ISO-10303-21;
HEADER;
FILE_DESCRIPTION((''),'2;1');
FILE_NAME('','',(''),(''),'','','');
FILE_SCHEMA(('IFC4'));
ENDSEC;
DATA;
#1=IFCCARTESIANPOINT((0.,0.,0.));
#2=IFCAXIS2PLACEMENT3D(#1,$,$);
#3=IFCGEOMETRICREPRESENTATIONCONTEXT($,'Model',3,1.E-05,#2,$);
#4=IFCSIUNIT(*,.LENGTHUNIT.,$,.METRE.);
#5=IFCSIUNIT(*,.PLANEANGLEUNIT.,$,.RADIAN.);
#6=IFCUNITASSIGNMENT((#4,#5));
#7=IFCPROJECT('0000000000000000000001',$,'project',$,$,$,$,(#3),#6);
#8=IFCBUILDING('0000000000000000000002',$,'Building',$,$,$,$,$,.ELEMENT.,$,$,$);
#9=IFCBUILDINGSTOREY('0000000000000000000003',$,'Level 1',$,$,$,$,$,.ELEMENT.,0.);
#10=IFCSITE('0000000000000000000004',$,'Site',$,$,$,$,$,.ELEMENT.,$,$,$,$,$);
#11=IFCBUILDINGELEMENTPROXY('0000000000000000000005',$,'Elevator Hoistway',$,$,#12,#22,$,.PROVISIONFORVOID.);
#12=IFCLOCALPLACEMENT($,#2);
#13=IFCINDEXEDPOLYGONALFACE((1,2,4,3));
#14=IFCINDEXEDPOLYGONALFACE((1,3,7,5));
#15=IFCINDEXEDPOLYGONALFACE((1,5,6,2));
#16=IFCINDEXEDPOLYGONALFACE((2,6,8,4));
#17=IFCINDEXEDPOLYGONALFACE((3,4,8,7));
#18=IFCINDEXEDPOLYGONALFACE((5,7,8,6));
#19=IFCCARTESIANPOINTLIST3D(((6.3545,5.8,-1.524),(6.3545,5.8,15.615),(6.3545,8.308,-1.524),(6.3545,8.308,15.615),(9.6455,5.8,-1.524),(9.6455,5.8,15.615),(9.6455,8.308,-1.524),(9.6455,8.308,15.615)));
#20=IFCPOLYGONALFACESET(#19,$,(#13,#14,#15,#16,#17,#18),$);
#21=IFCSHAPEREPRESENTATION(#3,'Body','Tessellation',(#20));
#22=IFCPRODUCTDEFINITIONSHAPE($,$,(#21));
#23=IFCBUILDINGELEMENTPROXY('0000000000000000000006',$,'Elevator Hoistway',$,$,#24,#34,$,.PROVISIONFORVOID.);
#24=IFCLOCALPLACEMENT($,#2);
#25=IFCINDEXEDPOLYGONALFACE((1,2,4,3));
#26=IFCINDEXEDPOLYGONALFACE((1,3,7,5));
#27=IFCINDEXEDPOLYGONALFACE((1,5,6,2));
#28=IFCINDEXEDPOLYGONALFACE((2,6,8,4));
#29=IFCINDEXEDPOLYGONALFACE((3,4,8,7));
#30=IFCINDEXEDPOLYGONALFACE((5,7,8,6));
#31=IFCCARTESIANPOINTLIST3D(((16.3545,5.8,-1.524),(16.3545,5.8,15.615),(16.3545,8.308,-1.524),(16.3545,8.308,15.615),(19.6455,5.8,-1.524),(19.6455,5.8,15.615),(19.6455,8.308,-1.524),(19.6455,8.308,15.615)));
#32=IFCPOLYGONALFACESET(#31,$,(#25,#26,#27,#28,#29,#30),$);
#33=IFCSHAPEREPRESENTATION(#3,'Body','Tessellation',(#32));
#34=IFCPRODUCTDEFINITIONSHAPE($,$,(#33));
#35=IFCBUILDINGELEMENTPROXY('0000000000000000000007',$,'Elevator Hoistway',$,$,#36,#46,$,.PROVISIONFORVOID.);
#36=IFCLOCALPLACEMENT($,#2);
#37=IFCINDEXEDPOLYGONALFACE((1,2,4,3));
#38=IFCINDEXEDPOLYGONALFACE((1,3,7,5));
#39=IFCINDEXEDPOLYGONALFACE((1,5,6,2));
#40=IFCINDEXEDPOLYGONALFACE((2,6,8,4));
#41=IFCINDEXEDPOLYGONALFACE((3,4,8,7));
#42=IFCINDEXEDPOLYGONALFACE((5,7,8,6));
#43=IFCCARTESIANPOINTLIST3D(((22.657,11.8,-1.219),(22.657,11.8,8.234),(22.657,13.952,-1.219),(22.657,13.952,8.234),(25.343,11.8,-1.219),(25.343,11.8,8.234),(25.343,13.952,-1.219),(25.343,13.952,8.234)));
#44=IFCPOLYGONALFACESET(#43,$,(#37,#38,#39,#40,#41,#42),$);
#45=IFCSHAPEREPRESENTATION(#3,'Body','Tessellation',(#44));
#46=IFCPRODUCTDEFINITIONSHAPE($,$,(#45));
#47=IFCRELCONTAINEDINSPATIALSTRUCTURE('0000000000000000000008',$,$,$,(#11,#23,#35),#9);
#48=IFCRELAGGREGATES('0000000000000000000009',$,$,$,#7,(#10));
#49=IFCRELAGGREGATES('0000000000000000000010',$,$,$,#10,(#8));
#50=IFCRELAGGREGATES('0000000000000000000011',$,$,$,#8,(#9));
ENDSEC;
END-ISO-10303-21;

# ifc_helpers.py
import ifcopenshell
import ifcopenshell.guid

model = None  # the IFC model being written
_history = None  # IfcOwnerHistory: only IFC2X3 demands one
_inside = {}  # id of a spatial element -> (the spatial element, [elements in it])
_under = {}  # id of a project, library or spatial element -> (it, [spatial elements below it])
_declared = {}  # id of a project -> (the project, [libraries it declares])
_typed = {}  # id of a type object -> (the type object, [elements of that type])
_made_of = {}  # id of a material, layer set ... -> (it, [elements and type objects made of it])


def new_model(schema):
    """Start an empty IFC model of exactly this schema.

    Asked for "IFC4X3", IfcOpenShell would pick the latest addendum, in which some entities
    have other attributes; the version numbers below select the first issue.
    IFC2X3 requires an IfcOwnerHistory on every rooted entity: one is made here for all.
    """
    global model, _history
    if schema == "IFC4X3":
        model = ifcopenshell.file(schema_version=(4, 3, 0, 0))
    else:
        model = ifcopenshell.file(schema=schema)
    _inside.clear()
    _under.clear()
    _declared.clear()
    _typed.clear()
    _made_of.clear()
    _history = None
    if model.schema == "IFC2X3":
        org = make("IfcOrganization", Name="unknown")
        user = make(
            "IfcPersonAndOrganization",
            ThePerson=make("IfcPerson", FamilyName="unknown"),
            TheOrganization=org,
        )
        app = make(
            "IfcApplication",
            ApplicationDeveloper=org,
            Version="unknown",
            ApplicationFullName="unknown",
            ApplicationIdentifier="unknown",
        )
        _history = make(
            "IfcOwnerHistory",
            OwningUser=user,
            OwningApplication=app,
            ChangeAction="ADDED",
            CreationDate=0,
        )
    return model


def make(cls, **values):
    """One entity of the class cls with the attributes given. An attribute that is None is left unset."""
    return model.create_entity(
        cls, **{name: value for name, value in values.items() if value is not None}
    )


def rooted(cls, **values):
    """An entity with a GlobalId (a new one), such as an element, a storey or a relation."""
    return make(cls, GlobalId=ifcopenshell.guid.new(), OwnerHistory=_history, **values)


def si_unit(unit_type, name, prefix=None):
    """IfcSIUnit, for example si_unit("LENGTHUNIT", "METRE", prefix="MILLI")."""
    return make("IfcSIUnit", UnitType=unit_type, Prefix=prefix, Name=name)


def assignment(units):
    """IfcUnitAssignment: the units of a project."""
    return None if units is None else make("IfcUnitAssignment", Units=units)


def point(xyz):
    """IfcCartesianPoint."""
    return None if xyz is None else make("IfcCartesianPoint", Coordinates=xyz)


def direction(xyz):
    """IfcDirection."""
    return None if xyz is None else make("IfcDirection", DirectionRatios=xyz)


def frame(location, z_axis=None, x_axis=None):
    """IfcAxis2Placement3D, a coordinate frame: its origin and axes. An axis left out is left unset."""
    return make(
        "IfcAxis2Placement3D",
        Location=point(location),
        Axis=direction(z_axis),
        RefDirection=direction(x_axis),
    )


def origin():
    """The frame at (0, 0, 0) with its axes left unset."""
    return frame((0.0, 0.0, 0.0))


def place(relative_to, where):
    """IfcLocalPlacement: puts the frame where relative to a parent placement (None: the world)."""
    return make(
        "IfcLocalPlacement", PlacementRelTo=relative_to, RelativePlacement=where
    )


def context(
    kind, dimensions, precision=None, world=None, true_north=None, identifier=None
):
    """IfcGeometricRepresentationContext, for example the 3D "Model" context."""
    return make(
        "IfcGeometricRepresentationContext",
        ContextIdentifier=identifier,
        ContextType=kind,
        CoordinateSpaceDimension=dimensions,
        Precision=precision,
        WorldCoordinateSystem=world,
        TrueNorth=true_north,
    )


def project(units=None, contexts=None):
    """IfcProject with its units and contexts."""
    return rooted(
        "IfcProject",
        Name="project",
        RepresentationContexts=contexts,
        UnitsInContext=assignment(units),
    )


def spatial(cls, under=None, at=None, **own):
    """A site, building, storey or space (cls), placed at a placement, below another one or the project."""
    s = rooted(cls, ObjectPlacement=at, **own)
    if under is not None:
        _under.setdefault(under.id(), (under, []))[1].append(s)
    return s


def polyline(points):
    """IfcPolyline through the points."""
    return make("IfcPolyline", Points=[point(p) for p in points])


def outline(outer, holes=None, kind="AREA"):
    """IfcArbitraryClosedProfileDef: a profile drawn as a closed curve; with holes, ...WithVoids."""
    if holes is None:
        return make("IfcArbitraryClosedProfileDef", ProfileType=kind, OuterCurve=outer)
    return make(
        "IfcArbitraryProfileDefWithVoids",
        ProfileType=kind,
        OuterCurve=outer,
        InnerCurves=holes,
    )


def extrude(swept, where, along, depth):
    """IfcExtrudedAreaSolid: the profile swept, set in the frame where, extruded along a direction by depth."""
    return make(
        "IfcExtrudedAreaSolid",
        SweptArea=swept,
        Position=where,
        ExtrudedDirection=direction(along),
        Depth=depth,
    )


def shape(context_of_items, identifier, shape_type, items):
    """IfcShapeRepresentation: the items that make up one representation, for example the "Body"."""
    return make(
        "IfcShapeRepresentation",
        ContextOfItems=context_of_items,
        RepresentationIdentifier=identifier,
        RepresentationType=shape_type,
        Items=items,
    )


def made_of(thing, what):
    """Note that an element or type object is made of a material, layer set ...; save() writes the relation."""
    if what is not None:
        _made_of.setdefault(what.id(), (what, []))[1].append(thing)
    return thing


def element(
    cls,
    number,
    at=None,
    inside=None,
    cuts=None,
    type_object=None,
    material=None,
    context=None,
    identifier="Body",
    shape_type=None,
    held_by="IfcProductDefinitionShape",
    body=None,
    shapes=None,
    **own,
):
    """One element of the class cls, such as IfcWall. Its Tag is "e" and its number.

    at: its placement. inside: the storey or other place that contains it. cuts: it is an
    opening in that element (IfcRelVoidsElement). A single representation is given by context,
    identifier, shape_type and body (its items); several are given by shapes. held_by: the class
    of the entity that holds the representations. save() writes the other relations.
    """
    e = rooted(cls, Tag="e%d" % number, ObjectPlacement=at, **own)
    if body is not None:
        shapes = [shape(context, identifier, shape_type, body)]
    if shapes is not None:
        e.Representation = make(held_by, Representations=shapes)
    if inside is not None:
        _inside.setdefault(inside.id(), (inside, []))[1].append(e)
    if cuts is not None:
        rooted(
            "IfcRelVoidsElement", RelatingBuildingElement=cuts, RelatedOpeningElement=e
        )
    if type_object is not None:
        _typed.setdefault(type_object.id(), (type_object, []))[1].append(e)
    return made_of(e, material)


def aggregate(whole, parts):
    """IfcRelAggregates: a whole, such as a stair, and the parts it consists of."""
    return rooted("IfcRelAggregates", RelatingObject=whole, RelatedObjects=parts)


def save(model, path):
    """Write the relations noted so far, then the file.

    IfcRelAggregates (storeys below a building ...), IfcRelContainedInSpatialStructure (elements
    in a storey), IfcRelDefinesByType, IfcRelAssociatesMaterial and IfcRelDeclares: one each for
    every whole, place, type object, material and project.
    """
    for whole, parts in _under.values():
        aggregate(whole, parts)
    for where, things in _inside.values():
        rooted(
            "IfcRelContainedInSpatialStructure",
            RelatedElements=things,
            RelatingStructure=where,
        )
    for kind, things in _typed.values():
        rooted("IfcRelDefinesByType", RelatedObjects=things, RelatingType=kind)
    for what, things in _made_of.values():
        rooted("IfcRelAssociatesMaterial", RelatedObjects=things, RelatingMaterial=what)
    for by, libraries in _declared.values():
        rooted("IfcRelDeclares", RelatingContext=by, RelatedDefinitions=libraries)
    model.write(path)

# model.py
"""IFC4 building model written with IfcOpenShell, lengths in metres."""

from ifc_helpers import new_model, si_unit, frame, origin, place, context, project, spatial, polyline, outline, extrude, element, save


model = new_model("IFC4")

# Units and contexts
model_context = context("Model", 3, precision=1e-05, world=origin())
ifc_project = project(units=[si_unit("LENGTHUNIT", "METRE"), si_unit("PLANEANGLEUNIT", "RADIAN")], contexts=[model_context])

# Site, building, storey
site = spatial("IfcSite", under=ifc_project, Name="Site", CompositionType="ELEMENT")
building = spatial("IfcBuilding", under=site, Name="Building", CompositionType="ELEMENT")
storey = spatial("IfcBuildingStorey", under=building, Name="Level 1", CompositionType="ELEMENT", Elevation=0.0)

# Building element proxies
proxy_1_placement = place(None, frame((0.0, 0.0, 15.615)))
element("IfcBuildingElementProxy", 1, at=proxy_1_placement, inside=storey, Name="Elevator Hoistway", PredefinedType="PROVISIONFORVOID", context=model_context, shape_type="SweptSolid", body=[
    extrude(outline(polyline([(6.3545, 5.8), (9.6455, 5.8), (9.6455, 8.308), (6.3545, 8.308), (6.3545, 5.8)])), origin(), (0.0, 0.0, -1.0), 17.139),
])
proxy_2_placement = place(None, frame((0.0, 0.0, 15.615)))
element("IfcBuildingElementProxy", 2, at=proxy_2_placement, inside=storey, Name="Elevator Hoistway", PredefinedType="PROVISIONFORVOID", context=model_context, shape_type="SweptSolid", body=[
    extrude(outline(polyline([(16.3545, 5.8), (19.6455, 5.8), (19.6455, 8.308), (16.3545, 8.308), (16.3545, 5.8)])), origin(), (0.0, 0.0, -1.0), 17.139),
])
proxy_3_placement = place(None, frame((0.0, 0.0, 8.234)))
element("IfcBuildingElementProxy", 3, at=proxy_3_placement, inside=storey, Name="Elevator Hoistway", PredefinedType="PROVISIONFORVOID", context=model_context, shape_type="SweptSolid", body=[
    extrude(outline(polyline([(22.657, 11.8), (25.343, 11.8), (25.343, 13.952), (22.657, 13.952), (22.657, 11.8)])), origin(), (0.0, 0.0, -1.0), 9.453),
])

save(model, "model.ifc")
